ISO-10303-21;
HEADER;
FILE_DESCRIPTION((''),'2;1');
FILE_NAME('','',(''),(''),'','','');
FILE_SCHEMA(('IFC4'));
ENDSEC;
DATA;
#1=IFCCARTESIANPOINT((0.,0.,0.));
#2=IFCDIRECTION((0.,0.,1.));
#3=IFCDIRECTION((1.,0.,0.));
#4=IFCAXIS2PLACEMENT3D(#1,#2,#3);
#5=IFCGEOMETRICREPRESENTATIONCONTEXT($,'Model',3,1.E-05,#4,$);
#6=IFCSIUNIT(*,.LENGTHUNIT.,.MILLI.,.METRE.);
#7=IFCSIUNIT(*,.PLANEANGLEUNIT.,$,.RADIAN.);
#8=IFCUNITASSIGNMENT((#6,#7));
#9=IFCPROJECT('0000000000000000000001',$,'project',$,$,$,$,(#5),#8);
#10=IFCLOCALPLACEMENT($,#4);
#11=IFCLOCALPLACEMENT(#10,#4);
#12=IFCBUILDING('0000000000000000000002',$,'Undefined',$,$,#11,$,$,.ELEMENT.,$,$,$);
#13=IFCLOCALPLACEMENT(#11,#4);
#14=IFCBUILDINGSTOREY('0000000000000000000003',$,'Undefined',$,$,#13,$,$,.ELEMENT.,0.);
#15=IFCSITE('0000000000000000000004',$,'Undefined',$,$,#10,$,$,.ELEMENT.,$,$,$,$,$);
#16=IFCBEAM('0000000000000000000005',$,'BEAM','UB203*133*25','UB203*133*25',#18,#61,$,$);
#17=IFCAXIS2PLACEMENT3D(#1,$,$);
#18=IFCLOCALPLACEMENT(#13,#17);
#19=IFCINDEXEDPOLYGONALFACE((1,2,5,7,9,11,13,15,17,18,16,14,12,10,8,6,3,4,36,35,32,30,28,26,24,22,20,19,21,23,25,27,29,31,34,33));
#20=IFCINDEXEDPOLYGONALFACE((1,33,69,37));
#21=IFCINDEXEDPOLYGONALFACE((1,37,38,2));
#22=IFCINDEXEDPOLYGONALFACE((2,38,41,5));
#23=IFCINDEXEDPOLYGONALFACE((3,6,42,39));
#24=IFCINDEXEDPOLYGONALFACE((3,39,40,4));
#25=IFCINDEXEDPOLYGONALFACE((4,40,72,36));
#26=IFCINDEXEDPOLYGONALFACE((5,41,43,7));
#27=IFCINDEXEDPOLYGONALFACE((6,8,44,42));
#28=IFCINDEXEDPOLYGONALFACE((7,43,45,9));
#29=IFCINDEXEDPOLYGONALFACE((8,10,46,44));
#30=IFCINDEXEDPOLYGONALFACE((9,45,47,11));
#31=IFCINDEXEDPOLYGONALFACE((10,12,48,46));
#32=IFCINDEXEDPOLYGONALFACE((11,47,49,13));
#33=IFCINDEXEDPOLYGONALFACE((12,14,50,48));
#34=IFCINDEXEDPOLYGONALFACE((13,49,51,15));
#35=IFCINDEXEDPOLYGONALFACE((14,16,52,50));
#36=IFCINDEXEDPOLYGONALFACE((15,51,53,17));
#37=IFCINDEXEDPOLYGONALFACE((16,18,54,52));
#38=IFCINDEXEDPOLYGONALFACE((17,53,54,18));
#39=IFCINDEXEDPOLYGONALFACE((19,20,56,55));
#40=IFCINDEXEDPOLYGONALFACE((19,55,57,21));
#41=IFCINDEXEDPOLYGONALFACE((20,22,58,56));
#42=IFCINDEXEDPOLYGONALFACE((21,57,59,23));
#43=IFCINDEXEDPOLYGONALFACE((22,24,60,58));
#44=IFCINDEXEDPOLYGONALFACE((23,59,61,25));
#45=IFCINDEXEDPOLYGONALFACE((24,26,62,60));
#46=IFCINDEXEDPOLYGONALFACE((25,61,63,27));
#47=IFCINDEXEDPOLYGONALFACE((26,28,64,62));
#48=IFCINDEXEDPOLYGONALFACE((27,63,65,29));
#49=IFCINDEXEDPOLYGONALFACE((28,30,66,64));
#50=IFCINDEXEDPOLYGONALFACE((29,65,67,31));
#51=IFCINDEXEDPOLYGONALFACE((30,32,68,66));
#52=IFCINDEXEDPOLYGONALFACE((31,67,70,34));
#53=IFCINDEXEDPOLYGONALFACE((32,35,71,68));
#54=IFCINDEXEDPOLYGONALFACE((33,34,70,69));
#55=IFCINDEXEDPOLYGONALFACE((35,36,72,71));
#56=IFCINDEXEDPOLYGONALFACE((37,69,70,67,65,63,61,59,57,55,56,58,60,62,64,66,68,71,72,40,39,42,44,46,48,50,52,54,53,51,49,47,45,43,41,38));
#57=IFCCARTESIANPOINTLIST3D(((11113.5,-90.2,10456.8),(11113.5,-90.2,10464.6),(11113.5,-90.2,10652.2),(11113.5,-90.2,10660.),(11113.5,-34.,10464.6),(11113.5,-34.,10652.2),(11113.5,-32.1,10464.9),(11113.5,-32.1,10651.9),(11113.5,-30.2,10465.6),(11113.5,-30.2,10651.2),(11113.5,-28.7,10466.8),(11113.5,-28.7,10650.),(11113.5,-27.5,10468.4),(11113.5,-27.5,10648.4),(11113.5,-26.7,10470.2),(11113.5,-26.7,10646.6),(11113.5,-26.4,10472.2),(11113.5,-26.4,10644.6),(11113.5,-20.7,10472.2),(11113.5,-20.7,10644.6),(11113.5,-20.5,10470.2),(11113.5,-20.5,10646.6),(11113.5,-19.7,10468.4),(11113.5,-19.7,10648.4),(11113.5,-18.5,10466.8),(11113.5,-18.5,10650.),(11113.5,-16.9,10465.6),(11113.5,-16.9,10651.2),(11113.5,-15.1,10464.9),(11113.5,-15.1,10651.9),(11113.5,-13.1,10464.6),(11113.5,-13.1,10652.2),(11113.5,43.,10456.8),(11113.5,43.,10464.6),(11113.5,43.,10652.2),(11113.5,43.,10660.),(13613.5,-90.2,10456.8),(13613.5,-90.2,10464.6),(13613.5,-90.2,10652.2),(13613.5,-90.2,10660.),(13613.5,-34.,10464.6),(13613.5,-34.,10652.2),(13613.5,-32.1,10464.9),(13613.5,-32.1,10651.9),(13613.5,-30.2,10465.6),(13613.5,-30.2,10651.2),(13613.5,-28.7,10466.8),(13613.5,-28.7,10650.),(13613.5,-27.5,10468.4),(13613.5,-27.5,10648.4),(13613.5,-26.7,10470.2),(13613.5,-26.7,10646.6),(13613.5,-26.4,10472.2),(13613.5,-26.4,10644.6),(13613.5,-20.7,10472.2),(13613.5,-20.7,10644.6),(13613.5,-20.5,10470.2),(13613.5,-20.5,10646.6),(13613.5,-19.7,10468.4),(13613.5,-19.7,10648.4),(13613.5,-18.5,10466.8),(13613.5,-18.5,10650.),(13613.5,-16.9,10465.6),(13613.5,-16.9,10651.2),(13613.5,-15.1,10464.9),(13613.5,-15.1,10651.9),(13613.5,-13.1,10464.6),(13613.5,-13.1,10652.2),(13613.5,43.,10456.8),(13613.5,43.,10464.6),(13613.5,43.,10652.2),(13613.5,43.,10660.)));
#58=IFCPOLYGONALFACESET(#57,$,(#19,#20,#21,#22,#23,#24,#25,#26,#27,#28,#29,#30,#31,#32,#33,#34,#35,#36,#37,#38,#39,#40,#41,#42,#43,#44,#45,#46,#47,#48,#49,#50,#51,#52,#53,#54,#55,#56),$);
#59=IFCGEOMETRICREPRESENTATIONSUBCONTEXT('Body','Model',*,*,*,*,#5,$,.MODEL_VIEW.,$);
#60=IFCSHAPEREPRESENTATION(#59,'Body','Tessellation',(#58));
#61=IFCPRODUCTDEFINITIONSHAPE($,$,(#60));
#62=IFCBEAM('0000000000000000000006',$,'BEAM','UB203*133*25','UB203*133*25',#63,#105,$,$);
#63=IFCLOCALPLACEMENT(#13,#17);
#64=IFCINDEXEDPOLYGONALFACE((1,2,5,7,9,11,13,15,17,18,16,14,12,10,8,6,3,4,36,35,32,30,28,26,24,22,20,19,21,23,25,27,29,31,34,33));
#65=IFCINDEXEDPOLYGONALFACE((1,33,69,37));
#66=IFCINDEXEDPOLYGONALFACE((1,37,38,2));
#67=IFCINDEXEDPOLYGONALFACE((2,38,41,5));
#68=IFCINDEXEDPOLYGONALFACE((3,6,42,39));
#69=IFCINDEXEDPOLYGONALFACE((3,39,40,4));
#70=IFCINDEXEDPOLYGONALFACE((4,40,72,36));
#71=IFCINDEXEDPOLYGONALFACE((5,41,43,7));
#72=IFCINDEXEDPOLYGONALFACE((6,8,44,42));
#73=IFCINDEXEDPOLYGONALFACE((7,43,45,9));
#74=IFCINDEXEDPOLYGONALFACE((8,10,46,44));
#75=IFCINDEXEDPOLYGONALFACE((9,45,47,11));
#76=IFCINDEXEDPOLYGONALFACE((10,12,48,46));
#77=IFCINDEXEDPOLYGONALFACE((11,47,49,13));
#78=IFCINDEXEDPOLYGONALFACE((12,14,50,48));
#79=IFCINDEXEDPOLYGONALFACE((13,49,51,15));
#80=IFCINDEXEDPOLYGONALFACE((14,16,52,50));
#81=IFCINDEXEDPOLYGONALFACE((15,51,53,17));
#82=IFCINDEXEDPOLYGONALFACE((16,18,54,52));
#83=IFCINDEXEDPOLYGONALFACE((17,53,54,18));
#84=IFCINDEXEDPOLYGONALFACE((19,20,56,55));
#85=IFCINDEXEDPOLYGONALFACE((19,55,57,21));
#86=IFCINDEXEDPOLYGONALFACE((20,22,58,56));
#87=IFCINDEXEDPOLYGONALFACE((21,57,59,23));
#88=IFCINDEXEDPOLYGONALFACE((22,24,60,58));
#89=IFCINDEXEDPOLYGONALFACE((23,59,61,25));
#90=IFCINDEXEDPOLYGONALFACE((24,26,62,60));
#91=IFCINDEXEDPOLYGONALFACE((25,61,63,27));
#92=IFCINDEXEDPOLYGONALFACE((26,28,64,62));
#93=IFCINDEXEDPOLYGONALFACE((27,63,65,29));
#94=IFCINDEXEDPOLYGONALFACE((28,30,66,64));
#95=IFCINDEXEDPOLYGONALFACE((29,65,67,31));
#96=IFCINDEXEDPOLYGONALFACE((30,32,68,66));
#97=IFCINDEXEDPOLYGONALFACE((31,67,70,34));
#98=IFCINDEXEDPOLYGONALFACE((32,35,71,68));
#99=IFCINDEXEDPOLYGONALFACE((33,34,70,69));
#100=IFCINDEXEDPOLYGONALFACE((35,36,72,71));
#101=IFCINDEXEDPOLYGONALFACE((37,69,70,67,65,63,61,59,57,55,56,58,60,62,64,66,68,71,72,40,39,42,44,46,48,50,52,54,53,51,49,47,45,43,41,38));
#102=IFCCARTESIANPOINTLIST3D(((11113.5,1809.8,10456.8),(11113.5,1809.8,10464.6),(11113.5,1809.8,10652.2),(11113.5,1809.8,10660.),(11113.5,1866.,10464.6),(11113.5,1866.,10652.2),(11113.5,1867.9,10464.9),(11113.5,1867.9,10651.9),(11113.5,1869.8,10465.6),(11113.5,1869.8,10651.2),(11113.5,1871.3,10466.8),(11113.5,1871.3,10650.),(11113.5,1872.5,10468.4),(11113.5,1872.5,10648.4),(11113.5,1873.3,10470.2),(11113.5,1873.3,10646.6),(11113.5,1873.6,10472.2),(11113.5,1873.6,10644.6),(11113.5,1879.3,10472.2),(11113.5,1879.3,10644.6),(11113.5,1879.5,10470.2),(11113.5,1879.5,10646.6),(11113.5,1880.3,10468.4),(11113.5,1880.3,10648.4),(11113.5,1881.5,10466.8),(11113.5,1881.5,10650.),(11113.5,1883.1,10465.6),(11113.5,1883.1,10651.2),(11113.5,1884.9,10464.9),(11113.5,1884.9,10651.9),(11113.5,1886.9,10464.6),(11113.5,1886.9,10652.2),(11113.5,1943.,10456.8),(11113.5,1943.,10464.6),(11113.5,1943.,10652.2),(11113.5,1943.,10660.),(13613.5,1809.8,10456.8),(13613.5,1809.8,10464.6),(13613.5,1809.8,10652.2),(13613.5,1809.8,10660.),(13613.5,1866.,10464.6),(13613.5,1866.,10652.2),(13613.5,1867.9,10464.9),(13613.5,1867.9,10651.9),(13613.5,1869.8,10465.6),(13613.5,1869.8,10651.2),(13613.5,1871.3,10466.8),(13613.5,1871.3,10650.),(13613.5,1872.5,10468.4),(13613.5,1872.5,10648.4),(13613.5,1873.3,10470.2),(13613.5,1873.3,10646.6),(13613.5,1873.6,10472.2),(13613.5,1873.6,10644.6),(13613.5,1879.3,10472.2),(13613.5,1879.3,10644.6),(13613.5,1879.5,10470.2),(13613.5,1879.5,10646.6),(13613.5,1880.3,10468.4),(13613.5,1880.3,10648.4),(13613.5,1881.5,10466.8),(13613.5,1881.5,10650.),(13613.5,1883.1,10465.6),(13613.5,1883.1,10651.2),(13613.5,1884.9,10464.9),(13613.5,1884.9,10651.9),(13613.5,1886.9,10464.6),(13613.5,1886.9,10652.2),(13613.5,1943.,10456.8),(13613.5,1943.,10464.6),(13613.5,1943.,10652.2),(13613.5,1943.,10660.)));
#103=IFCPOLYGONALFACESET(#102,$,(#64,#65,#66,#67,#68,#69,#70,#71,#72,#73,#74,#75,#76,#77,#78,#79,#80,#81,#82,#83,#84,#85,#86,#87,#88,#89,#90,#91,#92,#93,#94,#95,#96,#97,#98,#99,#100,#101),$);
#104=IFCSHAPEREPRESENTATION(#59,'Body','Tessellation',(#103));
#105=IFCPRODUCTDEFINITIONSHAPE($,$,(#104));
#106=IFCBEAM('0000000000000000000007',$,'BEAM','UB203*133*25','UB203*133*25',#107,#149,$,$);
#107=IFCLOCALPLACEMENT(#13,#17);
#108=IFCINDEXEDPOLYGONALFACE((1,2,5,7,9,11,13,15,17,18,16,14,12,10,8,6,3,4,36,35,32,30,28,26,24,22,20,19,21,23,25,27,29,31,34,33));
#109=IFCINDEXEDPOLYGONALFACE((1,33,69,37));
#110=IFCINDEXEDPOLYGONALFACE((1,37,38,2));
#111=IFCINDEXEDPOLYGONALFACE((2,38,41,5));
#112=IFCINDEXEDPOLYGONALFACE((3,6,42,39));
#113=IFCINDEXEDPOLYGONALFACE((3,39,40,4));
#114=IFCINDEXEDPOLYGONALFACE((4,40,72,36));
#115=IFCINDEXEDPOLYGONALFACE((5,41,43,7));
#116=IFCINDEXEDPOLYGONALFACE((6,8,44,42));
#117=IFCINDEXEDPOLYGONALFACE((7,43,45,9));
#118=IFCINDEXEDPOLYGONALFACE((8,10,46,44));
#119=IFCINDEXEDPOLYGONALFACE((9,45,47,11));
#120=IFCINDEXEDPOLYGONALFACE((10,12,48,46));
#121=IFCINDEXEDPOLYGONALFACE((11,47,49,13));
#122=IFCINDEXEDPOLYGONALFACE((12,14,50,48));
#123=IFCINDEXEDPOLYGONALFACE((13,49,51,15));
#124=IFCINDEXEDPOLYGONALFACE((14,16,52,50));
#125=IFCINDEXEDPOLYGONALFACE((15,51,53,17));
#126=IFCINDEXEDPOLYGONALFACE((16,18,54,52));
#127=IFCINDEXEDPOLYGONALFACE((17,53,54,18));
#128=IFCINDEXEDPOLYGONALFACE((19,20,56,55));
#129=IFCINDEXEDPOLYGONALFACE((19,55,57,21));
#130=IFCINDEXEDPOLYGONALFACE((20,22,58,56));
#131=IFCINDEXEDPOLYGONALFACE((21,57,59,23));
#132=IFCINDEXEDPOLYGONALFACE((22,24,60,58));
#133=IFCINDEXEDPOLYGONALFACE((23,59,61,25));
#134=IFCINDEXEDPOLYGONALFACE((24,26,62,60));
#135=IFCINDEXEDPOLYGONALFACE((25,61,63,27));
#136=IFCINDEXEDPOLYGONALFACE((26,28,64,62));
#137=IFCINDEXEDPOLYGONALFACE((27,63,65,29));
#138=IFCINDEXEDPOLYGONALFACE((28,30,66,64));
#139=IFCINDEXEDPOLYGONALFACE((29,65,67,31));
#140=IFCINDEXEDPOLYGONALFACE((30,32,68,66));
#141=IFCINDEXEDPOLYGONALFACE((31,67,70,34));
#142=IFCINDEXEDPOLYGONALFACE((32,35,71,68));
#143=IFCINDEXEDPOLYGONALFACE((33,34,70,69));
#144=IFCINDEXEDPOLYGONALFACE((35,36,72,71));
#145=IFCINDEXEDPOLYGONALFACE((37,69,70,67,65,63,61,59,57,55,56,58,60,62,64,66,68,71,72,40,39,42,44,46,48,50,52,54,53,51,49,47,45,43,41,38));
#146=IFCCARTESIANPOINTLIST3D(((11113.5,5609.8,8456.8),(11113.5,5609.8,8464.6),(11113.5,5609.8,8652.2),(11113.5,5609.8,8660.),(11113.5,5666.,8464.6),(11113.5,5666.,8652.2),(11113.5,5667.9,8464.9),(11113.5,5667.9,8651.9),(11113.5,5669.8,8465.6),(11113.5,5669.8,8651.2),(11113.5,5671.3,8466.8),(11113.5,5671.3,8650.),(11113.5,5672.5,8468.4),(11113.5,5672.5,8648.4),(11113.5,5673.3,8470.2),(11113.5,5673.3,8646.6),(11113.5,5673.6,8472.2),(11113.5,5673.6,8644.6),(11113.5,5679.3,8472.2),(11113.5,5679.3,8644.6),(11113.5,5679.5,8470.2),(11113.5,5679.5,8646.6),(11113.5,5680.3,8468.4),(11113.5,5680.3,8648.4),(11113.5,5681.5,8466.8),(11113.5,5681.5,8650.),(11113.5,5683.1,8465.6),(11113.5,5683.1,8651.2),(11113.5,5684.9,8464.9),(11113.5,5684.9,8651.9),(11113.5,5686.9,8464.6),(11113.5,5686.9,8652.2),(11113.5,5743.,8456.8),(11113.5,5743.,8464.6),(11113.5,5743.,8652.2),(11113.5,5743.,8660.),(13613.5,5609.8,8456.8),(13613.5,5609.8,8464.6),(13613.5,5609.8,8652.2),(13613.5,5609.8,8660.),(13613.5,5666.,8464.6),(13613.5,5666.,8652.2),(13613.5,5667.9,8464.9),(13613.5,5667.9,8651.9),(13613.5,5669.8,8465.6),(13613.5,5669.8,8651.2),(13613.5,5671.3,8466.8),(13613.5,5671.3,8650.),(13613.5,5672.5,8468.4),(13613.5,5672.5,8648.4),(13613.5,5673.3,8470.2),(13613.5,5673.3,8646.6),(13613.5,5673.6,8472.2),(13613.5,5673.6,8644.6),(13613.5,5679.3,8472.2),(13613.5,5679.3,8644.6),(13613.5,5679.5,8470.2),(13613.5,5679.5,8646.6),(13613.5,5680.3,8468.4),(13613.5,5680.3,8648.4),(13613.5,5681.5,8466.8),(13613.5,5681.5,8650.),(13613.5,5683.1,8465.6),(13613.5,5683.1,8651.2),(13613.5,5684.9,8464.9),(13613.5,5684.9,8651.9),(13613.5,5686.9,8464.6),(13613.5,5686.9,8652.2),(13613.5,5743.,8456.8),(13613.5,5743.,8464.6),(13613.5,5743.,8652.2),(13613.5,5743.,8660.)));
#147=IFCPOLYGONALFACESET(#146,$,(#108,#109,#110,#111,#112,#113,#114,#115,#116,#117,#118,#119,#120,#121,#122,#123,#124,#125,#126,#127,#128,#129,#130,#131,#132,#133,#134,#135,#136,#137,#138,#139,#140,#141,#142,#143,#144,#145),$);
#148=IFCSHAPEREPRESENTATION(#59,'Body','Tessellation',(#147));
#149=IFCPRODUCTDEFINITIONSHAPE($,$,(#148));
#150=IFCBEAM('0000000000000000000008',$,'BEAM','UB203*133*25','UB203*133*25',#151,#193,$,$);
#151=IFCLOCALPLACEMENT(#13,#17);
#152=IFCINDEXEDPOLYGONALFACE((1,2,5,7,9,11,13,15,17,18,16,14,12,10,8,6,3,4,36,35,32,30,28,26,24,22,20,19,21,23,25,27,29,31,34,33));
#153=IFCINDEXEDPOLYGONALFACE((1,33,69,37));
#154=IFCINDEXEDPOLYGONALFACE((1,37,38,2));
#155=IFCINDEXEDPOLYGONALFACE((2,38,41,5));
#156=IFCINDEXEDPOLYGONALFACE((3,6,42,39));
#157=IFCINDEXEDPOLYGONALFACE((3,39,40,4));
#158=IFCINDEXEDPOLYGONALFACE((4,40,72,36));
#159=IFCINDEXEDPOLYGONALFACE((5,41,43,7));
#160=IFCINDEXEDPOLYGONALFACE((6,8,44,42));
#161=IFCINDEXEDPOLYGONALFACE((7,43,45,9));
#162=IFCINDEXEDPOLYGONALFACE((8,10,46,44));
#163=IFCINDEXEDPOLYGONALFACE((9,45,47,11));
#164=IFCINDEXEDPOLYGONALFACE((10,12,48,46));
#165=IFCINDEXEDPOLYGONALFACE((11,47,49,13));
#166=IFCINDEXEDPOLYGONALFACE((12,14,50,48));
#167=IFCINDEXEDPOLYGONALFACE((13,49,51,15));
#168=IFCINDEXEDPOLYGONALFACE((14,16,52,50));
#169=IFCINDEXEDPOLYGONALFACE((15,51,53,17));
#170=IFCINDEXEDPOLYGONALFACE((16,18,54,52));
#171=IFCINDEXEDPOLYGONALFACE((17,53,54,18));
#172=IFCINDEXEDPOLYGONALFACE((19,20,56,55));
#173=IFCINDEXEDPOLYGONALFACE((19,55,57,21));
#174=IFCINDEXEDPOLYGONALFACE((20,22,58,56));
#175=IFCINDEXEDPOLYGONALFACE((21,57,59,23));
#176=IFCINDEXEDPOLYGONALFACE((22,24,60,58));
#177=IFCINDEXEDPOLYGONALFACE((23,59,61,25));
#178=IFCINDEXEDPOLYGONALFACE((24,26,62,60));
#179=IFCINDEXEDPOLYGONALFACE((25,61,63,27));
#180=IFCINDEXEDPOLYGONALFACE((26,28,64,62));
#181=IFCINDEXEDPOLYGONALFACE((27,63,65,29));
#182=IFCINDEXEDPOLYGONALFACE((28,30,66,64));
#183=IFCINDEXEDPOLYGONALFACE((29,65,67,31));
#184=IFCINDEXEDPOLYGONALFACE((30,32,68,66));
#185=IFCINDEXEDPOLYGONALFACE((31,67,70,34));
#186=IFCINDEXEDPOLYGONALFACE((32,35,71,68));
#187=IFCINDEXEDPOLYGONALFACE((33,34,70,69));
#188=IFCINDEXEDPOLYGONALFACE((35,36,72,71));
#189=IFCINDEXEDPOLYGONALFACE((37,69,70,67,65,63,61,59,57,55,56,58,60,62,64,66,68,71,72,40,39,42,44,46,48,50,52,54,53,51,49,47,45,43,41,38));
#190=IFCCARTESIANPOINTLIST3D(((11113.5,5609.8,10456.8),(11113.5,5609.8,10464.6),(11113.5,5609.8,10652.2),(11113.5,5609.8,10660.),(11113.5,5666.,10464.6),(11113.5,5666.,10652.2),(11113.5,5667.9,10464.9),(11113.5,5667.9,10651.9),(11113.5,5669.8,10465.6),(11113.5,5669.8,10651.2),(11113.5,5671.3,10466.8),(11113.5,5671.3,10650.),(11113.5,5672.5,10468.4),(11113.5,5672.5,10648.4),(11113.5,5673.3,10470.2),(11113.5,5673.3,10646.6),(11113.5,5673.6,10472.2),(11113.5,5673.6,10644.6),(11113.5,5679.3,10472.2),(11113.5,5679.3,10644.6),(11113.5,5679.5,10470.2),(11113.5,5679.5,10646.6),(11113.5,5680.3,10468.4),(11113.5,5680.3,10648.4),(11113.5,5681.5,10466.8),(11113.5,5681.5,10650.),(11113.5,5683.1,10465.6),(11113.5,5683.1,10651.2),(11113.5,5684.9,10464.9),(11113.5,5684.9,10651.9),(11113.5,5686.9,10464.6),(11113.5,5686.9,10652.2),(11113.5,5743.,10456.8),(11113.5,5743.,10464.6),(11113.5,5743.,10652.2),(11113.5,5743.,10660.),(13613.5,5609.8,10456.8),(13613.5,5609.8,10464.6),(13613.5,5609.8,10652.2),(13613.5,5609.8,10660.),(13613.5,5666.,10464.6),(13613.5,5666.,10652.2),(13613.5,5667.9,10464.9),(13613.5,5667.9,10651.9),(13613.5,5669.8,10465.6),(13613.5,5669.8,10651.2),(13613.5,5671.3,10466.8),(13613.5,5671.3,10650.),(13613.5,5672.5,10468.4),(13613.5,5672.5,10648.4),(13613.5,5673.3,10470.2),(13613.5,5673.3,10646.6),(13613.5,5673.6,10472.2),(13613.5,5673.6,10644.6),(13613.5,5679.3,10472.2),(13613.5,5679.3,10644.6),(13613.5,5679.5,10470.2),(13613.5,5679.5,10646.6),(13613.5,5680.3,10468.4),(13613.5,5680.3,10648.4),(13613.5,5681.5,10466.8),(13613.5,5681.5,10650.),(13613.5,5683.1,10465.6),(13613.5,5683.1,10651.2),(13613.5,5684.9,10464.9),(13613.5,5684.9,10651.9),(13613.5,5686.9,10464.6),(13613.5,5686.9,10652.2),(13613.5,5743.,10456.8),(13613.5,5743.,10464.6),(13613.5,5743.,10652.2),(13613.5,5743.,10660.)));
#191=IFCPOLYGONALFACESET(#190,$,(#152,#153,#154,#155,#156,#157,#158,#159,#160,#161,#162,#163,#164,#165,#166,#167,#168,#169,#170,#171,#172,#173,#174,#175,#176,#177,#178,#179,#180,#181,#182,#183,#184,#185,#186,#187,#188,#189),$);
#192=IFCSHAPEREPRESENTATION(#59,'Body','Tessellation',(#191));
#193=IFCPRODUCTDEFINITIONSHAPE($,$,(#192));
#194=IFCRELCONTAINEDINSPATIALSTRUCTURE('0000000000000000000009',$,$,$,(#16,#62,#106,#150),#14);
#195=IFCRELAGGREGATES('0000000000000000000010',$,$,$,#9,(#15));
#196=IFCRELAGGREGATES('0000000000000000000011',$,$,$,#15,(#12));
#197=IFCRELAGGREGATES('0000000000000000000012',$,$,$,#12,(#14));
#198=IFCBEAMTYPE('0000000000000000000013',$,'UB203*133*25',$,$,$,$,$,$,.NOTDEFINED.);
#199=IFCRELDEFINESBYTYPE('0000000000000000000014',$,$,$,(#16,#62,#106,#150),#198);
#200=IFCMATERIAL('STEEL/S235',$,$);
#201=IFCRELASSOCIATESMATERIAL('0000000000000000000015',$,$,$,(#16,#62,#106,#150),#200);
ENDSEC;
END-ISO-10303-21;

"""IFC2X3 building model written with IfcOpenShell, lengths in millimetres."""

from ifc_helpers import new_model, si_unit, frame, origin_with_axes, origin_2d_with_axis, place, context, subcontext, project, spatial, i_section, extrude, material, type_object, element, save


model = new_model("IFC2X3")

# Units and contexts
model_context = context("Model", 3, precision=1e-05, world=origin_with_axes())
body_context = subcontext(model_context, "Body", "Model", "MODEL_VIEW")
ifc_project = project(units=[si_unit("LENGTHUNIT", "METRE", prefix="MILLI"), si_unit("PLANEANGLEUNIT", "RADIAN")], contexts=[model_context])

# Site, building, storey
site_placement = place(None, origin_with_axes())
site = spatial("IfcSite", under=ifc_project, at=site_placement, Name="Undefined", CompositionType="ELEMENT")
building_placement = place(site_placement, origin_with_axes())
building = spatial("IfcBuilding", under=site, at=building_placement, Name="Undefined", CompositionType="ELEMENT")
storey_placement = place(building_placement, origin_with_axes())
storey = spatial("IfcBuildingStorey", under=building, at=storey_placement, Name="Undefined", CompositionType="ELEMENT", Elevation=0.0)

# Shared definitions
ifc_material = material(Name="STEEL/S235")

# Beams
beam_type_1 = type_object("IfcBeamType", Name="UB203*133*25", PredefinedType="NOTDEFINED")
for number, where, z_axis, x_axis, name in (
    (1, (11113.5, -23.6, 10558.4), (0.0, 0.0, 1.0), (1.0, 0.0, 0.0), "BEAM"),
    (2, (11113.5, 1876.4, 10558.4), (0.0, 0.0, 1.0), (1.0, 0.0, 0.0), "BEAM"),
    (3, (11113.5, 5676.4, 8558.4), (0.0, 0.0, 1.0), (1.0, 0.0, 0.0), "BEAM"),
    (4, (11113.5, 5676.4, 10558.4), (0.0, 0.0, 1.0), (1.0, 0.0, 0.0), "BEAM"),
):
    element("IfcBeam", number, at=place(storey_placement, frame(where, z_axis=z_axis, x_axis=x_axis)), inside=storey, type_object=beam_type_1, material=ifc_material, Name=name, Description="UB203*133*25", ObjectType="UB203*133*25", context=body_context, shape_type="SweptSolid", body=[
        extrude(i_section(OverallWidth=133.2, OverallDepth=203.2, WebThickness=5.7, FlangeThickness=7.8, FilletRadius=7.6, at=origin_2d_with_axis()), frame((2500.0, 0.0, 0.0), z_axis=(-1.0, 0.0, 0.0), x_axis=(0.0, -1.0, 0.0)), (0.0, 0.0, 1.0), 2500.0),
    ])

save(model, "model.ifc")
